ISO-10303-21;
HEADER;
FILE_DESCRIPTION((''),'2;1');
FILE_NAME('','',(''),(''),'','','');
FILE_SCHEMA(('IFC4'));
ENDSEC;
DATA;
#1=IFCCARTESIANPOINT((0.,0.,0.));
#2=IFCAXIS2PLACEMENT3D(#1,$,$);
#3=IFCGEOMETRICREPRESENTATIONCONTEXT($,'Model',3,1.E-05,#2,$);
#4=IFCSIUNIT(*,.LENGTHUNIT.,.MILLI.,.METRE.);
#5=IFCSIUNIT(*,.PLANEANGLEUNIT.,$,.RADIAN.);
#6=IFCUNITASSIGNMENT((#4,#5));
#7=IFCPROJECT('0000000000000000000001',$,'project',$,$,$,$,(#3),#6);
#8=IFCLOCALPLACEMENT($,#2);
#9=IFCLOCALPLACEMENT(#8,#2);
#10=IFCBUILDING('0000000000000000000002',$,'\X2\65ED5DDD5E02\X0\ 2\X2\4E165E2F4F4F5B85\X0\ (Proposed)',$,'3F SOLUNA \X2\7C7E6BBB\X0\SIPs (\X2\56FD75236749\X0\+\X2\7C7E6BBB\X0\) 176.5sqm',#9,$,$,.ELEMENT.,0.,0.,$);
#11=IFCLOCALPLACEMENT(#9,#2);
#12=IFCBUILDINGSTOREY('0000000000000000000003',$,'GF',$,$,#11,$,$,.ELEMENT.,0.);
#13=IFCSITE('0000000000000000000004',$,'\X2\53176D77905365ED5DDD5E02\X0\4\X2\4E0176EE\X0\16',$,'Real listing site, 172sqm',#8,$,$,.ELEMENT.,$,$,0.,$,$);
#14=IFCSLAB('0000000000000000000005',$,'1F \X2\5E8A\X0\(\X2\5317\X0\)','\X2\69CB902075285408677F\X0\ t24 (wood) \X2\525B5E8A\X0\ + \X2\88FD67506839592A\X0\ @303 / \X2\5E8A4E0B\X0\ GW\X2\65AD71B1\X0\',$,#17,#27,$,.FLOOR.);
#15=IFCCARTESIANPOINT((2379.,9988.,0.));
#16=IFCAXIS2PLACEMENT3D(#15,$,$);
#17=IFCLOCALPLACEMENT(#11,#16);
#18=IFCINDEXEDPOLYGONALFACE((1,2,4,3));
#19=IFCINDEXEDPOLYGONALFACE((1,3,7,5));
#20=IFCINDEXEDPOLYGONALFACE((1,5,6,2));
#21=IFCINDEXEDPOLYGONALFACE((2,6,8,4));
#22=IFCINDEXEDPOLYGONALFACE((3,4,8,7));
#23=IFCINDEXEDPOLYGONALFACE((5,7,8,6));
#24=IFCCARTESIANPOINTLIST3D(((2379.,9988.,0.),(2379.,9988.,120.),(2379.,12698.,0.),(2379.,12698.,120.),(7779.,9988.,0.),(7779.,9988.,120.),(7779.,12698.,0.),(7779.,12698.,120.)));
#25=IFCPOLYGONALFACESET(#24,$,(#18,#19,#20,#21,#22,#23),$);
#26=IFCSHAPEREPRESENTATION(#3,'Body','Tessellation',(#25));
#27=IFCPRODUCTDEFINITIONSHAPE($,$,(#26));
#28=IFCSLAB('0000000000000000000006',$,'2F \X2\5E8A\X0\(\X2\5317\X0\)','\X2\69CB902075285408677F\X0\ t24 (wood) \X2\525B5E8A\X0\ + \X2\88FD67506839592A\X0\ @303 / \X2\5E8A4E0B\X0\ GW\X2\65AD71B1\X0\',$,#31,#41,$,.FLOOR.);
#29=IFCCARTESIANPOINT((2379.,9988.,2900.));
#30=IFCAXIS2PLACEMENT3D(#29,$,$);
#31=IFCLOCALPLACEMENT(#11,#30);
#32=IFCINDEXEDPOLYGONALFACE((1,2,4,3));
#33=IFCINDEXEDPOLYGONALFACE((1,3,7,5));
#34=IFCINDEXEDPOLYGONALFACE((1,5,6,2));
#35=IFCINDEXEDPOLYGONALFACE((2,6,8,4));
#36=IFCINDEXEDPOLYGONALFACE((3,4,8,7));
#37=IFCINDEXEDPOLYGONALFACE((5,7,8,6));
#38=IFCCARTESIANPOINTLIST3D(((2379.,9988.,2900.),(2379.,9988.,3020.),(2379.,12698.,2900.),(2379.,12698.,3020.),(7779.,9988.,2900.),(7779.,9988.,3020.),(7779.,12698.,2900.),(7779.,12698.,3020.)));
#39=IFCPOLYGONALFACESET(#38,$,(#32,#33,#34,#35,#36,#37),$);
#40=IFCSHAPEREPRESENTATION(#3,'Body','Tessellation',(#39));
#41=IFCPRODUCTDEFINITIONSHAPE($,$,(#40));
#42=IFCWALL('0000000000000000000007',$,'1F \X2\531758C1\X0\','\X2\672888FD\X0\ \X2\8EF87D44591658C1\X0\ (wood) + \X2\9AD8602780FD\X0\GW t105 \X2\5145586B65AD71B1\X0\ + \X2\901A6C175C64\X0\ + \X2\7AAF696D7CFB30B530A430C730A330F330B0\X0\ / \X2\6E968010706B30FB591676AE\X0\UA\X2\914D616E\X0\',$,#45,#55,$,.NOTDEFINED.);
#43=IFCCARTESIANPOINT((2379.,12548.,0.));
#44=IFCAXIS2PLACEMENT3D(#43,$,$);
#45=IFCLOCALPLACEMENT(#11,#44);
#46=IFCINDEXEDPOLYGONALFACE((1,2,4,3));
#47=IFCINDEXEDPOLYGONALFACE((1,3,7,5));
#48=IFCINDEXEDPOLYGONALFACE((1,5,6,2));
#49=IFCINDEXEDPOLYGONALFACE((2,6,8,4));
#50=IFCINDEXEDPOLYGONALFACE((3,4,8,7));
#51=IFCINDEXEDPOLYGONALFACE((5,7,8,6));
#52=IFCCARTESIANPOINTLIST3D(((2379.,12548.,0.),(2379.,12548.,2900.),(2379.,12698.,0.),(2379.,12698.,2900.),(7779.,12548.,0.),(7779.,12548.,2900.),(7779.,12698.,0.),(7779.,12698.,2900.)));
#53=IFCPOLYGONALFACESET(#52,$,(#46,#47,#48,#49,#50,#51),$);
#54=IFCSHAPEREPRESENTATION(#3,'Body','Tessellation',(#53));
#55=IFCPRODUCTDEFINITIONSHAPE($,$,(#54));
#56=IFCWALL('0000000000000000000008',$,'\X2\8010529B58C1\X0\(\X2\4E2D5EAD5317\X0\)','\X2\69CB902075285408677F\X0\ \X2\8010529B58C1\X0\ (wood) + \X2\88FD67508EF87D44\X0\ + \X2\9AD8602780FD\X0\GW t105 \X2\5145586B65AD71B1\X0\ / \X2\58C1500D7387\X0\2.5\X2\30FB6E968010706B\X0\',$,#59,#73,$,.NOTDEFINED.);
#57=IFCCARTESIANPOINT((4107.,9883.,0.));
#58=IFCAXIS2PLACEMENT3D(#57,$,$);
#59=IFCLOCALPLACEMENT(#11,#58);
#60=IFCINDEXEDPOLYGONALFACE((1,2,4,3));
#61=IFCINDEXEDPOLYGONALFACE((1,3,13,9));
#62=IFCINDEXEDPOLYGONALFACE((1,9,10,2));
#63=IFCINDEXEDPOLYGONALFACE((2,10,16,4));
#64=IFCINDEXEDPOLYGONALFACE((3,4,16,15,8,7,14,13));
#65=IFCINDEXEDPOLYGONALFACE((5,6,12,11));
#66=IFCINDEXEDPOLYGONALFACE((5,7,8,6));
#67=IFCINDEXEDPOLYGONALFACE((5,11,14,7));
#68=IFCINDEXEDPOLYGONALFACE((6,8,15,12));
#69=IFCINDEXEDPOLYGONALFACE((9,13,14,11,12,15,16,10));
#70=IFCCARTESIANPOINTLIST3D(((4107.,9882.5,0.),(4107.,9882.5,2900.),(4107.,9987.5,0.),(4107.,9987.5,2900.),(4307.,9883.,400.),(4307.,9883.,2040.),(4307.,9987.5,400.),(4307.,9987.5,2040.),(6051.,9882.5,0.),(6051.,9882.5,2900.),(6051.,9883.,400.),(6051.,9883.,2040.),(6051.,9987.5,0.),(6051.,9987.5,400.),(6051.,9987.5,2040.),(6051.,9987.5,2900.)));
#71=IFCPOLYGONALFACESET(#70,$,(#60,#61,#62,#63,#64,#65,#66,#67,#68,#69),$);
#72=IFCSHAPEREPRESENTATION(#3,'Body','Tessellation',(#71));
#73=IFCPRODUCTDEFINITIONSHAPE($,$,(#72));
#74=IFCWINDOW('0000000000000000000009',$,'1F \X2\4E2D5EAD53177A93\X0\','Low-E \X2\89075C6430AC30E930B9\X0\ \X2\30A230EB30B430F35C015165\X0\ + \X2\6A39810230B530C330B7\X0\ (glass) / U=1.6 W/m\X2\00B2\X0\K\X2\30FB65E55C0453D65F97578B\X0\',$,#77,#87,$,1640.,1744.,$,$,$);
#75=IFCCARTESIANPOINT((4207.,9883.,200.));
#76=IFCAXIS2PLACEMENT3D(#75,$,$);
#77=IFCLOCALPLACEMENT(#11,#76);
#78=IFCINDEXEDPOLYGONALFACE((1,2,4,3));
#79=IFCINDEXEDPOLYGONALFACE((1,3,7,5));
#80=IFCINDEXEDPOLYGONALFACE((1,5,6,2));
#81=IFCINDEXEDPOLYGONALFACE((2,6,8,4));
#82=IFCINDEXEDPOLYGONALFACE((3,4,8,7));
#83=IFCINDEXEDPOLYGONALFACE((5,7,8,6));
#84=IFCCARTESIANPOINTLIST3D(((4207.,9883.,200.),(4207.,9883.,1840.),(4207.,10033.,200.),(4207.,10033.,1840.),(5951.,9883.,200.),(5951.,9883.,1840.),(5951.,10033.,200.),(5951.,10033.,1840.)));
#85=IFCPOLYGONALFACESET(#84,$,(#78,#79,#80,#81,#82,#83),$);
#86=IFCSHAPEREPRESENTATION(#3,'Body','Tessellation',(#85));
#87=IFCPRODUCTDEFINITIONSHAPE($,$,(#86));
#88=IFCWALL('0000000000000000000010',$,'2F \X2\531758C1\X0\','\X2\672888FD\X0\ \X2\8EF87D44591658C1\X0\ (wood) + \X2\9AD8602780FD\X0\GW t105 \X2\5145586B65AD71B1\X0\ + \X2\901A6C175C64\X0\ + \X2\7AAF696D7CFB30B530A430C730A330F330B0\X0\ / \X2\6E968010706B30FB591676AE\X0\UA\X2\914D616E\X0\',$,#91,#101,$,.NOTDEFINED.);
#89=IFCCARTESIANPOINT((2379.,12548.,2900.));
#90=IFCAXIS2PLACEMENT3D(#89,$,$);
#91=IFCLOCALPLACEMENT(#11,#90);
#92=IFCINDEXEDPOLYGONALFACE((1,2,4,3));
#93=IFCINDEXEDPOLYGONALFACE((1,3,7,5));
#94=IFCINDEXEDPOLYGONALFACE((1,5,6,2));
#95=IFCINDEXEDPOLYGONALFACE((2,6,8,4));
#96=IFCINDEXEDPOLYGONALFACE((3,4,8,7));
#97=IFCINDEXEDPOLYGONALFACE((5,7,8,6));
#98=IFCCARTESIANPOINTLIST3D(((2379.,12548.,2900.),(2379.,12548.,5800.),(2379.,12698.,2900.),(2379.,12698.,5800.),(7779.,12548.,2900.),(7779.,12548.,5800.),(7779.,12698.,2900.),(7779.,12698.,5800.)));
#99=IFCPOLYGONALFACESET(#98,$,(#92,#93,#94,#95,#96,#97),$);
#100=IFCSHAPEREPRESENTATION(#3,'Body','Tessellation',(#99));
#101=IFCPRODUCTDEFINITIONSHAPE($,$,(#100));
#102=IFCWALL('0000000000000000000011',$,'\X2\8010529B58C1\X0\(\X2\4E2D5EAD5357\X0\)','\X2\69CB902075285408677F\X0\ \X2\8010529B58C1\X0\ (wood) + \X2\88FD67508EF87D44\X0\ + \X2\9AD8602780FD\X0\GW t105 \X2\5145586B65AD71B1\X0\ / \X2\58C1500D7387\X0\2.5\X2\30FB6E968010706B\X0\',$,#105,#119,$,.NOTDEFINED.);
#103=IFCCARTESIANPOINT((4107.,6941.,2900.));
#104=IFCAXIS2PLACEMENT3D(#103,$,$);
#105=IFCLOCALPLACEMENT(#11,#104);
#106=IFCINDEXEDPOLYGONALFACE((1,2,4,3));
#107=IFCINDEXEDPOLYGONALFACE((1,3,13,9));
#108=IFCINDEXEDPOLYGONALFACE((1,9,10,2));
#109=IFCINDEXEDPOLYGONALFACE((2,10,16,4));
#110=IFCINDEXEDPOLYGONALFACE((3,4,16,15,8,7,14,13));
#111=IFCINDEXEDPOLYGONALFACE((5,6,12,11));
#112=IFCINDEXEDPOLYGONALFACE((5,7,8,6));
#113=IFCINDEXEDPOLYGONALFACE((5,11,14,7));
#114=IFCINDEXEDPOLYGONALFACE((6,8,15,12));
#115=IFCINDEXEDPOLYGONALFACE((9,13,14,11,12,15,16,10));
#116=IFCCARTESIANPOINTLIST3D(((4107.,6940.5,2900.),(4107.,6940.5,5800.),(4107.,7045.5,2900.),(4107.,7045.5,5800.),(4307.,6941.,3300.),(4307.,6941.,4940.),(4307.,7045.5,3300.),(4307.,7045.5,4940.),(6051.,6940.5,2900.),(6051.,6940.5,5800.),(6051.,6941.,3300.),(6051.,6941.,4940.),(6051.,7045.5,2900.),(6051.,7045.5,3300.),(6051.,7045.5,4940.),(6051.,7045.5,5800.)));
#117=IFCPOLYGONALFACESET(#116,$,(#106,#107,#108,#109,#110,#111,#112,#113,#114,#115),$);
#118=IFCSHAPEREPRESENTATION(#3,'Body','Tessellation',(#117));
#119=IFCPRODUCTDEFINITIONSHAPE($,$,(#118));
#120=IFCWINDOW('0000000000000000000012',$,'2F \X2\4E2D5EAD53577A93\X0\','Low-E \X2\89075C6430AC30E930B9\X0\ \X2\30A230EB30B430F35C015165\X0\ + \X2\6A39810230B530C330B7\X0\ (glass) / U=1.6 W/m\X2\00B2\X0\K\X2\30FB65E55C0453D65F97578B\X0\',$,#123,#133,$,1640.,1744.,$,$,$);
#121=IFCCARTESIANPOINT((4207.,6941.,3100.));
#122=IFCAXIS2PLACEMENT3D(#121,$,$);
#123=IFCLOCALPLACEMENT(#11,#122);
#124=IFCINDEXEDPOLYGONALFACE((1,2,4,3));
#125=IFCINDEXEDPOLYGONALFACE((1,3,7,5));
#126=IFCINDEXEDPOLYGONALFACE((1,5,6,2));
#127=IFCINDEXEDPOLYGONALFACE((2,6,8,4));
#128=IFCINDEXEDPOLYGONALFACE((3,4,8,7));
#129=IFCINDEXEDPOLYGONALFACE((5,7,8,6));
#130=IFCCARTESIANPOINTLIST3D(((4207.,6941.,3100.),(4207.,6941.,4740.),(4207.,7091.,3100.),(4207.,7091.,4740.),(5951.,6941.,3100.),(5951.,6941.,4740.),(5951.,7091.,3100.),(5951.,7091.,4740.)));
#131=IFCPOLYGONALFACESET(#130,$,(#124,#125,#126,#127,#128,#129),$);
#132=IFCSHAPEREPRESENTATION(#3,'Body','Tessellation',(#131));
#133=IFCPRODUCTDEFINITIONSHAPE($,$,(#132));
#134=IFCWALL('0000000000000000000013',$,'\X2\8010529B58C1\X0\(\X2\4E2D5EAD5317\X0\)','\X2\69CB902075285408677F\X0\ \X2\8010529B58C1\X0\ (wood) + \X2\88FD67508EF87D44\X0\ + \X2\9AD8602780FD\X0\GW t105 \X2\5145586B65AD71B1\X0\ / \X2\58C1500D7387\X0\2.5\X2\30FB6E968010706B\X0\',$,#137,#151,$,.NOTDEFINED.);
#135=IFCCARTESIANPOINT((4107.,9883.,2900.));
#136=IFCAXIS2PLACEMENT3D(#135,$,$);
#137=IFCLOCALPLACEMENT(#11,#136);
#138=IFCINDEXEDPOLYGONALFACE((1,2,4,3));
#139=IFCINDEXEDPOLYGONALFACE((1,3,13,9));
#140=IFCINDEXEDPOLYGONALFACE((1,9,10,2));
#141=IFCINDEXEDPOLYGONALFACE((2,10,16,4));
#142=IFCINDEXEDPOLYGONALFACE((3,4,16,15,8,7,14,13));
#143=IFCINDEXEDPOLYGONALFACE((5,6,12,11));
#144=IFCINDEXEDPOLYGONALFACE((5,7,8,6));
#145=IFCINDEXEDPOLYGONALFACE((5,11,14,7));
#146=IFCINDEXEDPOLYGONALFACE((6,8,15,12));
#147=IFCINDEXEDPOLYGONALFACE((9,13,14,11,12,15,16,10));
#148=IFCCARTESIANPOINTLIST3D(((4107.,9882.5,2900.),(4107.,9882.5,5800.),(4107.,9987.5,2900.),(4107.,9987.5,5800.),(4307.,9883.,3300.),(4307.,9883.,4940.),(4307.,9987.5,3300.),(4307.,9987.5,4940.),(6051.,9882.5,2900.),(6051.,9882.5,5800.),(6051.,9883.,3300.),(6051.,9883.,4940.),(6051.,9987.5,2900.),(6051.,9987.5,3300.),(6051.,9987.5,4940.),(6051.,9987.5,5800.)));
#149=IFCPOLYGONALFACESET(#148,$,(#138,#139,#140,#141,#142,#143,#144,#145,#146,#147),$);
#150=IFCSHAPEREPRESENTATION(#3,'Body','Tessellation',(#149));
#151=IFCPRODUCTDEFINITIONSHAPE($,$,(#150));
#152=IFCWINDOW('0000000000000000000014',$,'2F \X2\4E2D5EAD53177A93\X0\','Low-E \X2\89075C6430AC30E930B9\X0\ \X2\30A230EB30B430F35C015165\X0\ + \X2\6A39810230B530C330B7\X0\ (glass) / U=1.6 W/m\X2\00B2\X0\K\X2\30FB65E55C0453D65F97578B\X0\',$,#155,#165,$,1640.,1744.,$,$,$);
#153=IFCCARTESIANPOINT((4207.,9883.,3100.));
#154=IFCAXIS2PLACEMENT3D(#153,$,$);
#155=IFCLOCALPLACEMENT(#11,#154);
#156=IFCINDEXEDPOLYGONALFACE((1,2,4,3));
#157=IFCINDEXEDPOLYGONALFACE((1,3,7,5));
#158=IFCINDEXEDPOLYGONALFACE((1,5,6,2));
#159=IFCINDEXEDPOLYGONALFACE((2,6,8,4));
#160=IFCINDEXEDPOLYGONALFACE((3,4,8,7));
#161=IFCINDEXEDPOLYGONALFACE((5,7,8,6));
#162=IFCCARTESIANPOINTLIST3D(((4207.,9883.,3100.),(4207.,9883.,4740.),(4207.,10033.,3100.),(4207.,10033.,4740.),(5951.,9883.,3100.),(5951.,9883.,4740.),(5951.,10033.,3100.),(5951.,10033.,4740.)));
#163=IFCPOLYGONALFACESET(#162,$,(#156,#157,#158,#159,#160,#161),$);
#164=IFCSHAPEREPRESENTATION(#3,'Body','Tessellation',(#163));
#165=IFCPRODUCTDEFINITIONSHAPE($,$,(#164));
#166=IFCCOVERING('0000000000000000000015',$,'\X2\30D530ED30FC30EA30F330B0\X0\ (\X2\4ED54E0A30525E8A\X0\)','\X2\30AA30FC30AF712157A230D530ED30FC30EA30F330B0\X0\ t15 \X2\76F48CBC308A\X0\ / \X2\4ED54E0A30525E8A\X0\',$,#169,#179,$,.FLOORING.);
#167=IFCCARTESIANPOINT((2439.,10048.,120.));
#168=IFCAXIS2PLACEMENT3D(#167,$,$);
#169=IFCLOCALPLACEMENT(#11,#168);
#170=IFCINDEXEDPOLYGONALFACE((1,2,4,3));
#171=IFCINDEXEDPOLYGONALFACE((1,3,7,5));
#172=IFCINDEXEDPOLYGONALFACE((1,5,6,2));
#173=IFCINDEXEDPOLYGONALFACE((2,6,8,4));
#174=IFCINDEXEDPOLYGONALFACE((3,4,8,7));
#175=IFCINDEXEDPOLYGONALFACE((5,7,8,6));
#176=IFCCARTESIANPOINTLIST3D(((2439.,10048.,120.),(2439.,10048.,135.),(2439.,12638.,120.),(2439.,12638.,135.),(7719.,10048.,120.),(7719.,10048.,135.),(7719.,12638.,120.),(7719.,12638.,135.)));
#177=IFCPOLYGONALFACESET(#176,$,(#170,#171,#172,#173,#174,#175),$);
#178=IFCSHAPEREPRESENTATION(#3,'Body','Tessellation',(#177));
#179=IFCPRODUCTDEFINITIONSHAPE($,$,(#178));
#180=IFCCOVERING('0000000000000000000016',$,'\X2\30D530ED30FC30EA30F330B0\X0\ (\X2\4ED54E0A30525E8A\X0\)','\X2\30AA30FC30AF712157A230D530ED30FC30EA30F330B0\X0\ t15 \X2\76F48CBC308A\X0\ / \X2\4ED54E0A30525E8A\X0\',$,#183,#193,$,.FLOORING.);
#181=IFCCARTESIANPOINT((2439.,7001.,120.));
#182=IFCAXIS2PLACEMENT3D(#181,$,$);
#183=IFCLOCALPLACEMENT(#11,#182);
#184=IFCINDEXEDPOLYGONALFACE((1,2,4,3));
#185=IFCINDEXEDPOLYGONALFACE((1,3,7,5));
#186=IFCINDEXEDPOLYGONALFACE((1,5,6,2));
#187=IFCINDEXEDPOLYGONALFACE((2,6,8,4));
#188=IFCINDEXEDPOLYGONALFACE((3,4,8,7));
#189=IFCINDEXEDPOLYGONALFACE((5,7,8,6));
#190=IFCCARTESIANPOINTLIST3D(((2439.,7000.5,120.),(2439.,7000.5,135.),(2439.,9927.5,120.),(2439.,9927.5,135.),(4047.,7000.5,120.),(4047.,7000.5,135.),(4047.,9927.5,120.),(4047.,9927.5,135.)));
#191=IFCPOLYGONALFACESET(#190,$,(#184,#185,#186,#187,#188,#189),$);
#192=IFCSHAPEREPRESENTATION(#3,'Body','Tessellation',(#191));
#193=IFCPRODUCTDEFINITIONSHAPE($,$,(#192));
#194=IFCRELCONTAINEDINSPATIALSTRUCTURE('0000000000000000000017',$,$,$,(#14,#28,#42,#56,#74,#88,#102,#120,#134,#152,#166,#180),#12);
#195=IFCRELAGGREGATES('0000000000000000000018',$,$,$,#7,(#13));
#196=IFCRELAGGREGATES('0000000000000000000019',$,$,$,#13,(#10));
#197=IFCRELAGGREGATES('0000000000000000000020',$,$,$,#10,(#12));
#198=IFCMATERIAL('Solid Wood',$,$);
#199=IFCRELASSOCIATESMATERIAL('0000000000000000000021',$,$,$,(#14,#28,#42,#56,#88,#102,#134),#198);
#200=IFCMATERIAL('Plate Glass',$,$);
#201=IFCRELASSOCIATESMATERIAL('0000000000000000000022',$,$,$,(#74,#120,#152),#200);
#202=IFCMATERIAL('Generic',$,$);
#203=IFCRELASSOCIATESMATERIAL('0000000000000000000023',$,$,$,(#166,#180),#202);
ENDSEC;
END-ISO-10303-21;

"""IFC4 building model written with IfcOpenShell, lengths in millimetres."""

from ifc_helpers import new_model, si_unit, frame, frame_2d, origin, place, context, project, spatial, rectangle, extrude, material, element, fill, save


model = new_model("IFC4")

# Units and contexts
model_context = context("Model", 3, precision=1e-05, world=origin())
ifc_project = project(units=[si_unit("LENGTHUNIT", "METRE", prefix="MILLI"), si_unit("PLANEANGLEUNIT", "RADIAN")], contexts=[model_context])

# Site, building, storey
site_placement = place(None, origin())
site = spatial("IfcSite", under=ifc_project, at=site_placement, Name="北海道旭川市4丁目16", ObjectType="Real listing site, 172sqm", CompositionType="ELEMENT", RefElevation=0.0)
building_placement = place(site_placement, origin())
building = spatial("IfcBuilding", under=site, at=building_placement, Name="旭川市 2世帯住宅 (Proposed)", ObjectType="3F SOLUNA 籾殻SIPs (国産杉+籾殻) 176.5sqm", CompositionType="ELEMENT", ElevationOfRefHeight=0.0, ElevationOfTerrain=0.0)
storey_placement = place(building_placement, origin())
storey = spatial("IfcBuildingStorey", under=building, at=storey_placement, Name="GF", CompositionType="ELEMENT", Elevation=0.0)

# Slabs
ifc_material_1 = material(Name="Solid Wood")
slab_1_placement = place(storey_placement, frame((2379.0, 9988.0, 0.0)))
element("IfcSlab", 1, at=slab_1_placement, inside=storey, material=ifc_material_1, Name="1F 床(北)", Description="構造用合板 t24 (wood) 剛床 + 製材根太 @303 / 床下 GW断熱", PredefinedType="FLOOR", context=model_context, shape_type="SweptSolid", body=[
    extrude(rectangle(XDim=5400.0, YDim=2710.0, at=frame_2d((2700.0, 1355.0))), frame((2379.0, 9988.0, 0.0)), (0.0, 0.0, 1.0), 120.0),
])
slab_2_placement = place(storey_placement, frame((2379.0, 9988.0, 2900.0)))
element("IfcSlab", 2, at=slab_2_placement, inside=storey, material=ifc_material_1, Name="2F 床(北)", Description="構造用合板 t24 (wood) 剛床 + 製材根太 @303 / 床下 GW断熱", PredefinedType="FLOOR", context=model_context, shape_type="SweptSolid", body=[
    extrude(rectangle(XDim=5400.0, YDim=2710.0, at=frame_2d((2700.0, 1355.0))), frame((2379.0, 9988.0, 2900.0)), (0.0, 0.0, 1.0), 120.0),
])

# Wall
wall_1_placement = place(storey_placement, frame((2379.0, 12548.0, 0.0)))
element("IfcWall", 3, at=wall_1_placement, inside=storey, material=ifc_material_1, Name="1F 北壁", Description="木製 軸組外壁 (wood) + 高性能GW t105 充填断熱 + 通気層 + 窯業系サイディング / 準耐火・外皮UA配慮", PredefinedType="NOTDEFINED", context=model_context, shape_type="SweptSolid", body=[
    extrude(rectangle(XDim=5400.0, YDim=150.0, at=frame_2d((2700.0, 75.0))), frame((2379.0, 12548.0, 0.0)), (0.0, 0.0, 1.0), 2900.0),
])

# Wall, opening, window
wall_2_placement = place(storey_placement, frame((4107.0, 9883.0, 0.0)))
wall_2 = element("IfcWall", 4, at=wall_2_placement, inside=storey, material=ifc_material_1, Name="耐力壁(中庭北)", Description="構造用合板 耐力壁 (wood) + 製材軸組 + 高性能GW t105 充填断熱 / 壁倍率2.5・準耐火", PredefinedType="NOTDEFINED", context=model_context, shape_type="SweptSolid", body=[
    extrude(rectangle(XDim=1944.0, YDim=105.0, at=frame_2d((972.0, 52.0))), frame((4107.0, 9883.0, 0.0)), (0.0, 0.0, 1.0), 2900.0),
])
opening_1_placement = place(storey_placement, frame((4207.0, 9883.0, 200.0)))
opening_1 = element("IfcOpeningElement", 5, at=opening_1_placement, cuts=wall_2, PredefinedType="NOTDEFINED", context=model_context, shape_type="SweptSolid", body=[
    extrude(rectangle(XDim=1744.0, YDim=150.0, at=frame_2d((872.0, 75.0))), frame((4207.0, 9883.0, 200.0)), (0.0, 0.0, 1.0), 1640.0),
])
ifc_material_2 = material(Name="Plate Glass")
window_1_placement = place(storey_placement, frame((4207.0, 9883.0, 200.0)))
window_1 = element("IfcWindow", 6, at=window_1_placement, inside=storey, material=ifc_material_2, Name="1F 中庭北窓", Description="Low-E 複層ガラス アルゴン封入 + 樹脂サッシ (glass) / U=1.6 W/m²K・日射取得型", OverallHeight=1640.0, OverallWidth=1744.0, context=model_context, shape_type="SweptSolid", body=[
    extrude(rectangle(XDim=1744.0, YDim=150.0, at=frame_2d((872.0, 75.0))), frame((4207.0, 9883.0, 200.0)), (0.0, 0.0, 1.0), 1640.0),
])
fill(opening_1, window_1)

# Wall
wall_3_placement = place(storey_placement, frame((2379.0, 12548.0, 2900.0)))
element("IfcWall", 7, at=wall_3_placement, inside=storey, material=ifc_material_1, Name="2F 北壁", Description="木製 軸組外壁 (wood) + 高性能GW t105 充填断熱 + 通気層 + 窯業系サイディング / 準耐火・外皮UA配慮", PredefinedType="NOTDEFINED", context=model_context, shape_type="SweptSolid", body=[
    extrude(rectangle(XDim=5400.0, YDim=150.0, at=frame_2d((2700.0, 75.0))), frame((2379.0, 12548.0, 2900.0)), (0.0, 0.0, 1.0), 2900.0),
])

# Walls, openings, windows
wall_4_placement = place(storey_placement, frame((4107.0, 6941.0, 2900.0)))
wall_4 = element("IfcWall", 8, at=wall_4_placement, inside=storey, material=ifc_material_1, Name="耐力壁(中庭南)", Description="構造用合板 耐力壁 (wood) + 製材軸組 + 高性能GW t105 充填断熱 / 壁倍率2.5・準耐火", PredefinedType="NOTDEFINED", context=model_context, shape_type="SweptSolid", body=[
    extrude(rectangle(XDim=1944.0, YDim=105.0, at=frame_2d((972.0, 52.0))), frame((4107.0, 6941.0, 2900.0)), (0.0, 0.0, 1.0), 2900.0),
])
opening_2_placement = place(storey_placement, frame((4207.0, 6941.0, 3100.0)))
opening_2 = element("IfcOpeningElement", 9, at=opening_2_placement, cuts=wall_4, PredefinedType="NOTDEFINED", context=model_context, shape_type="SweptSolid", body=[
    extrude(rectangle(XDim=1744.0, YDim=150.0, at=frame_2d((872.0, 75.0))), frame((4207.0, 6941.0, 3100.0)), (0.0, 0.0, 1.0), 1640.0),
])
window_2_placement = place(storey_placement, frame((4207.0, 6941.0, 3100.0)))
window_2 = element("IfcWindow", 10, at=window_2_placement, inside=storey, material=ifc_material_2, Name="2F 中庭南窓", Description="Low-E 複層ガラス アルゴン封入 + 樹脂サッシ (glass) / U=1.6 W/m²K・日射取得型", OverallHeight=1640.0, OverallWidth=1744.0, context=model_context, shape_type="SweptSolid", body=[
    extrude(rectangle(XDim=1744.0, YDim=150.0, at=frame_2d((872.0, 75.0))), frame((4207.0, 6941.0, 3100.0)), (0.0, 0.0, 1.0), 1640.0),
])
fill(opening_2, window_2)
wall_5_placement = place(storey_placement, frame((4107.0, 9883.0, 2900.0)))
wall_5 = element("IfcWall", 11, at=wall_5_placement, inside=storey, material=ifc_material_1, Name="耐力壁(中庭北)", Description="構造用合板 耐力壁 (wood) + 製材軸組 + 高性能GW t105 充填断熱 / 壁倍率2.5・準耐火", PredefinedType="NOTDEFINED", context=model_context, shape_type="SweptSolid", body=[
    extrude(rectangle(XDim=1944.0, YDim=105.0, at=frame_2d((972.0, 52.0))), frame((4107.0, 9883.0, 2900.0)), (0.0, 0.0, 1.0), 2900.0),
])
opening_3_placement = place(storey_placement, frame((4207.0, 9883.0, 3100.0)))
opening_3 = element("IfcOpeningElement", 12, at=opening_3_placement, cuts=wall_5, PredefinedType="NOTDEFINED", context=model_context, shape_type="SweptSolid", body=[
    extrude(rectangle(XDim=1744.0, YDim=150.0, at=frame_2d((872.0, 75.0))), frame((4207.0, 9883.0, 3100.0)), (0.0, 0.0, 1.0), 1640.0),
])
window_3_placement = place(storey_placement, frame((4207.0, 9883.0, 3100.0)))
window_3 = element("IfcWindow", 13, at=window_3_placement, inside=storey, material=ifc_material_2, Name="2F 中庭北窓", Description="Low-E 複層ガラス アルゴン封入 + 樹脂サッシ (glass) / U=1.6 W/m²K・日射取得型", OverallHeight=1640.0, OverallWidth=1744.0, context=model_context, shape_type="SweptSolid", body=[
    extrude(rectangle(XDim=1744.0, YDim=150.0, at=frame_2d((872.0, 75.0))), frame((4207.0, 9883.0, 3100.0)), (0.0, 0.0, 1.0), 1640.0),
])
fill(opening_3, window_3)

# Coverings
ifc_material_3 = material(Name="Generic")
covering_1_placement = place(storey_placement, frame((2439.0, 10048.0, 120.0)))
element("IfcCovering", 14, at=covering_1_placement, inside=storey, material=ifc_material_3, Name="フローリング (仕上げ床)", Description="オーク無垢フローリング t15 直貼り / 仕上げ床", PredefinedType="FLOORING", context=model_context, shape_type="SweptSolid", body=[
    extrude(rectangle(XDim=5280.0, YDim=2590.0, at=frame_2d((2640.0, 1295.0))), frame((2439.0, 10048.0, 120.0)), (0.0, 0.0, 1.0), 15.0),
])
covering_2_placement = place(storey_placement, frame((2439.0, 7001.0, 120.0)))
element("IfcCovering", 15, at=covering_2_placement, inside=storey, material=ifc_material_3, Name="フローリング (仕上げ床)", Description="オーク無垢フローリング t15 直貼り / 仕上げ床", PredefinedType="FLOORING", context=model_context, shape_type="SweptSolid", body=[
    extrude(rectangle(XDim=1608.0, YDim=2927.0, at=frame_2d((804.0, 1463.0))), frame((2439.0, 7001.0, 120.0)), (0.0, 0.0, 1.0), 15.0),
])

save(model, "model.ifc")
